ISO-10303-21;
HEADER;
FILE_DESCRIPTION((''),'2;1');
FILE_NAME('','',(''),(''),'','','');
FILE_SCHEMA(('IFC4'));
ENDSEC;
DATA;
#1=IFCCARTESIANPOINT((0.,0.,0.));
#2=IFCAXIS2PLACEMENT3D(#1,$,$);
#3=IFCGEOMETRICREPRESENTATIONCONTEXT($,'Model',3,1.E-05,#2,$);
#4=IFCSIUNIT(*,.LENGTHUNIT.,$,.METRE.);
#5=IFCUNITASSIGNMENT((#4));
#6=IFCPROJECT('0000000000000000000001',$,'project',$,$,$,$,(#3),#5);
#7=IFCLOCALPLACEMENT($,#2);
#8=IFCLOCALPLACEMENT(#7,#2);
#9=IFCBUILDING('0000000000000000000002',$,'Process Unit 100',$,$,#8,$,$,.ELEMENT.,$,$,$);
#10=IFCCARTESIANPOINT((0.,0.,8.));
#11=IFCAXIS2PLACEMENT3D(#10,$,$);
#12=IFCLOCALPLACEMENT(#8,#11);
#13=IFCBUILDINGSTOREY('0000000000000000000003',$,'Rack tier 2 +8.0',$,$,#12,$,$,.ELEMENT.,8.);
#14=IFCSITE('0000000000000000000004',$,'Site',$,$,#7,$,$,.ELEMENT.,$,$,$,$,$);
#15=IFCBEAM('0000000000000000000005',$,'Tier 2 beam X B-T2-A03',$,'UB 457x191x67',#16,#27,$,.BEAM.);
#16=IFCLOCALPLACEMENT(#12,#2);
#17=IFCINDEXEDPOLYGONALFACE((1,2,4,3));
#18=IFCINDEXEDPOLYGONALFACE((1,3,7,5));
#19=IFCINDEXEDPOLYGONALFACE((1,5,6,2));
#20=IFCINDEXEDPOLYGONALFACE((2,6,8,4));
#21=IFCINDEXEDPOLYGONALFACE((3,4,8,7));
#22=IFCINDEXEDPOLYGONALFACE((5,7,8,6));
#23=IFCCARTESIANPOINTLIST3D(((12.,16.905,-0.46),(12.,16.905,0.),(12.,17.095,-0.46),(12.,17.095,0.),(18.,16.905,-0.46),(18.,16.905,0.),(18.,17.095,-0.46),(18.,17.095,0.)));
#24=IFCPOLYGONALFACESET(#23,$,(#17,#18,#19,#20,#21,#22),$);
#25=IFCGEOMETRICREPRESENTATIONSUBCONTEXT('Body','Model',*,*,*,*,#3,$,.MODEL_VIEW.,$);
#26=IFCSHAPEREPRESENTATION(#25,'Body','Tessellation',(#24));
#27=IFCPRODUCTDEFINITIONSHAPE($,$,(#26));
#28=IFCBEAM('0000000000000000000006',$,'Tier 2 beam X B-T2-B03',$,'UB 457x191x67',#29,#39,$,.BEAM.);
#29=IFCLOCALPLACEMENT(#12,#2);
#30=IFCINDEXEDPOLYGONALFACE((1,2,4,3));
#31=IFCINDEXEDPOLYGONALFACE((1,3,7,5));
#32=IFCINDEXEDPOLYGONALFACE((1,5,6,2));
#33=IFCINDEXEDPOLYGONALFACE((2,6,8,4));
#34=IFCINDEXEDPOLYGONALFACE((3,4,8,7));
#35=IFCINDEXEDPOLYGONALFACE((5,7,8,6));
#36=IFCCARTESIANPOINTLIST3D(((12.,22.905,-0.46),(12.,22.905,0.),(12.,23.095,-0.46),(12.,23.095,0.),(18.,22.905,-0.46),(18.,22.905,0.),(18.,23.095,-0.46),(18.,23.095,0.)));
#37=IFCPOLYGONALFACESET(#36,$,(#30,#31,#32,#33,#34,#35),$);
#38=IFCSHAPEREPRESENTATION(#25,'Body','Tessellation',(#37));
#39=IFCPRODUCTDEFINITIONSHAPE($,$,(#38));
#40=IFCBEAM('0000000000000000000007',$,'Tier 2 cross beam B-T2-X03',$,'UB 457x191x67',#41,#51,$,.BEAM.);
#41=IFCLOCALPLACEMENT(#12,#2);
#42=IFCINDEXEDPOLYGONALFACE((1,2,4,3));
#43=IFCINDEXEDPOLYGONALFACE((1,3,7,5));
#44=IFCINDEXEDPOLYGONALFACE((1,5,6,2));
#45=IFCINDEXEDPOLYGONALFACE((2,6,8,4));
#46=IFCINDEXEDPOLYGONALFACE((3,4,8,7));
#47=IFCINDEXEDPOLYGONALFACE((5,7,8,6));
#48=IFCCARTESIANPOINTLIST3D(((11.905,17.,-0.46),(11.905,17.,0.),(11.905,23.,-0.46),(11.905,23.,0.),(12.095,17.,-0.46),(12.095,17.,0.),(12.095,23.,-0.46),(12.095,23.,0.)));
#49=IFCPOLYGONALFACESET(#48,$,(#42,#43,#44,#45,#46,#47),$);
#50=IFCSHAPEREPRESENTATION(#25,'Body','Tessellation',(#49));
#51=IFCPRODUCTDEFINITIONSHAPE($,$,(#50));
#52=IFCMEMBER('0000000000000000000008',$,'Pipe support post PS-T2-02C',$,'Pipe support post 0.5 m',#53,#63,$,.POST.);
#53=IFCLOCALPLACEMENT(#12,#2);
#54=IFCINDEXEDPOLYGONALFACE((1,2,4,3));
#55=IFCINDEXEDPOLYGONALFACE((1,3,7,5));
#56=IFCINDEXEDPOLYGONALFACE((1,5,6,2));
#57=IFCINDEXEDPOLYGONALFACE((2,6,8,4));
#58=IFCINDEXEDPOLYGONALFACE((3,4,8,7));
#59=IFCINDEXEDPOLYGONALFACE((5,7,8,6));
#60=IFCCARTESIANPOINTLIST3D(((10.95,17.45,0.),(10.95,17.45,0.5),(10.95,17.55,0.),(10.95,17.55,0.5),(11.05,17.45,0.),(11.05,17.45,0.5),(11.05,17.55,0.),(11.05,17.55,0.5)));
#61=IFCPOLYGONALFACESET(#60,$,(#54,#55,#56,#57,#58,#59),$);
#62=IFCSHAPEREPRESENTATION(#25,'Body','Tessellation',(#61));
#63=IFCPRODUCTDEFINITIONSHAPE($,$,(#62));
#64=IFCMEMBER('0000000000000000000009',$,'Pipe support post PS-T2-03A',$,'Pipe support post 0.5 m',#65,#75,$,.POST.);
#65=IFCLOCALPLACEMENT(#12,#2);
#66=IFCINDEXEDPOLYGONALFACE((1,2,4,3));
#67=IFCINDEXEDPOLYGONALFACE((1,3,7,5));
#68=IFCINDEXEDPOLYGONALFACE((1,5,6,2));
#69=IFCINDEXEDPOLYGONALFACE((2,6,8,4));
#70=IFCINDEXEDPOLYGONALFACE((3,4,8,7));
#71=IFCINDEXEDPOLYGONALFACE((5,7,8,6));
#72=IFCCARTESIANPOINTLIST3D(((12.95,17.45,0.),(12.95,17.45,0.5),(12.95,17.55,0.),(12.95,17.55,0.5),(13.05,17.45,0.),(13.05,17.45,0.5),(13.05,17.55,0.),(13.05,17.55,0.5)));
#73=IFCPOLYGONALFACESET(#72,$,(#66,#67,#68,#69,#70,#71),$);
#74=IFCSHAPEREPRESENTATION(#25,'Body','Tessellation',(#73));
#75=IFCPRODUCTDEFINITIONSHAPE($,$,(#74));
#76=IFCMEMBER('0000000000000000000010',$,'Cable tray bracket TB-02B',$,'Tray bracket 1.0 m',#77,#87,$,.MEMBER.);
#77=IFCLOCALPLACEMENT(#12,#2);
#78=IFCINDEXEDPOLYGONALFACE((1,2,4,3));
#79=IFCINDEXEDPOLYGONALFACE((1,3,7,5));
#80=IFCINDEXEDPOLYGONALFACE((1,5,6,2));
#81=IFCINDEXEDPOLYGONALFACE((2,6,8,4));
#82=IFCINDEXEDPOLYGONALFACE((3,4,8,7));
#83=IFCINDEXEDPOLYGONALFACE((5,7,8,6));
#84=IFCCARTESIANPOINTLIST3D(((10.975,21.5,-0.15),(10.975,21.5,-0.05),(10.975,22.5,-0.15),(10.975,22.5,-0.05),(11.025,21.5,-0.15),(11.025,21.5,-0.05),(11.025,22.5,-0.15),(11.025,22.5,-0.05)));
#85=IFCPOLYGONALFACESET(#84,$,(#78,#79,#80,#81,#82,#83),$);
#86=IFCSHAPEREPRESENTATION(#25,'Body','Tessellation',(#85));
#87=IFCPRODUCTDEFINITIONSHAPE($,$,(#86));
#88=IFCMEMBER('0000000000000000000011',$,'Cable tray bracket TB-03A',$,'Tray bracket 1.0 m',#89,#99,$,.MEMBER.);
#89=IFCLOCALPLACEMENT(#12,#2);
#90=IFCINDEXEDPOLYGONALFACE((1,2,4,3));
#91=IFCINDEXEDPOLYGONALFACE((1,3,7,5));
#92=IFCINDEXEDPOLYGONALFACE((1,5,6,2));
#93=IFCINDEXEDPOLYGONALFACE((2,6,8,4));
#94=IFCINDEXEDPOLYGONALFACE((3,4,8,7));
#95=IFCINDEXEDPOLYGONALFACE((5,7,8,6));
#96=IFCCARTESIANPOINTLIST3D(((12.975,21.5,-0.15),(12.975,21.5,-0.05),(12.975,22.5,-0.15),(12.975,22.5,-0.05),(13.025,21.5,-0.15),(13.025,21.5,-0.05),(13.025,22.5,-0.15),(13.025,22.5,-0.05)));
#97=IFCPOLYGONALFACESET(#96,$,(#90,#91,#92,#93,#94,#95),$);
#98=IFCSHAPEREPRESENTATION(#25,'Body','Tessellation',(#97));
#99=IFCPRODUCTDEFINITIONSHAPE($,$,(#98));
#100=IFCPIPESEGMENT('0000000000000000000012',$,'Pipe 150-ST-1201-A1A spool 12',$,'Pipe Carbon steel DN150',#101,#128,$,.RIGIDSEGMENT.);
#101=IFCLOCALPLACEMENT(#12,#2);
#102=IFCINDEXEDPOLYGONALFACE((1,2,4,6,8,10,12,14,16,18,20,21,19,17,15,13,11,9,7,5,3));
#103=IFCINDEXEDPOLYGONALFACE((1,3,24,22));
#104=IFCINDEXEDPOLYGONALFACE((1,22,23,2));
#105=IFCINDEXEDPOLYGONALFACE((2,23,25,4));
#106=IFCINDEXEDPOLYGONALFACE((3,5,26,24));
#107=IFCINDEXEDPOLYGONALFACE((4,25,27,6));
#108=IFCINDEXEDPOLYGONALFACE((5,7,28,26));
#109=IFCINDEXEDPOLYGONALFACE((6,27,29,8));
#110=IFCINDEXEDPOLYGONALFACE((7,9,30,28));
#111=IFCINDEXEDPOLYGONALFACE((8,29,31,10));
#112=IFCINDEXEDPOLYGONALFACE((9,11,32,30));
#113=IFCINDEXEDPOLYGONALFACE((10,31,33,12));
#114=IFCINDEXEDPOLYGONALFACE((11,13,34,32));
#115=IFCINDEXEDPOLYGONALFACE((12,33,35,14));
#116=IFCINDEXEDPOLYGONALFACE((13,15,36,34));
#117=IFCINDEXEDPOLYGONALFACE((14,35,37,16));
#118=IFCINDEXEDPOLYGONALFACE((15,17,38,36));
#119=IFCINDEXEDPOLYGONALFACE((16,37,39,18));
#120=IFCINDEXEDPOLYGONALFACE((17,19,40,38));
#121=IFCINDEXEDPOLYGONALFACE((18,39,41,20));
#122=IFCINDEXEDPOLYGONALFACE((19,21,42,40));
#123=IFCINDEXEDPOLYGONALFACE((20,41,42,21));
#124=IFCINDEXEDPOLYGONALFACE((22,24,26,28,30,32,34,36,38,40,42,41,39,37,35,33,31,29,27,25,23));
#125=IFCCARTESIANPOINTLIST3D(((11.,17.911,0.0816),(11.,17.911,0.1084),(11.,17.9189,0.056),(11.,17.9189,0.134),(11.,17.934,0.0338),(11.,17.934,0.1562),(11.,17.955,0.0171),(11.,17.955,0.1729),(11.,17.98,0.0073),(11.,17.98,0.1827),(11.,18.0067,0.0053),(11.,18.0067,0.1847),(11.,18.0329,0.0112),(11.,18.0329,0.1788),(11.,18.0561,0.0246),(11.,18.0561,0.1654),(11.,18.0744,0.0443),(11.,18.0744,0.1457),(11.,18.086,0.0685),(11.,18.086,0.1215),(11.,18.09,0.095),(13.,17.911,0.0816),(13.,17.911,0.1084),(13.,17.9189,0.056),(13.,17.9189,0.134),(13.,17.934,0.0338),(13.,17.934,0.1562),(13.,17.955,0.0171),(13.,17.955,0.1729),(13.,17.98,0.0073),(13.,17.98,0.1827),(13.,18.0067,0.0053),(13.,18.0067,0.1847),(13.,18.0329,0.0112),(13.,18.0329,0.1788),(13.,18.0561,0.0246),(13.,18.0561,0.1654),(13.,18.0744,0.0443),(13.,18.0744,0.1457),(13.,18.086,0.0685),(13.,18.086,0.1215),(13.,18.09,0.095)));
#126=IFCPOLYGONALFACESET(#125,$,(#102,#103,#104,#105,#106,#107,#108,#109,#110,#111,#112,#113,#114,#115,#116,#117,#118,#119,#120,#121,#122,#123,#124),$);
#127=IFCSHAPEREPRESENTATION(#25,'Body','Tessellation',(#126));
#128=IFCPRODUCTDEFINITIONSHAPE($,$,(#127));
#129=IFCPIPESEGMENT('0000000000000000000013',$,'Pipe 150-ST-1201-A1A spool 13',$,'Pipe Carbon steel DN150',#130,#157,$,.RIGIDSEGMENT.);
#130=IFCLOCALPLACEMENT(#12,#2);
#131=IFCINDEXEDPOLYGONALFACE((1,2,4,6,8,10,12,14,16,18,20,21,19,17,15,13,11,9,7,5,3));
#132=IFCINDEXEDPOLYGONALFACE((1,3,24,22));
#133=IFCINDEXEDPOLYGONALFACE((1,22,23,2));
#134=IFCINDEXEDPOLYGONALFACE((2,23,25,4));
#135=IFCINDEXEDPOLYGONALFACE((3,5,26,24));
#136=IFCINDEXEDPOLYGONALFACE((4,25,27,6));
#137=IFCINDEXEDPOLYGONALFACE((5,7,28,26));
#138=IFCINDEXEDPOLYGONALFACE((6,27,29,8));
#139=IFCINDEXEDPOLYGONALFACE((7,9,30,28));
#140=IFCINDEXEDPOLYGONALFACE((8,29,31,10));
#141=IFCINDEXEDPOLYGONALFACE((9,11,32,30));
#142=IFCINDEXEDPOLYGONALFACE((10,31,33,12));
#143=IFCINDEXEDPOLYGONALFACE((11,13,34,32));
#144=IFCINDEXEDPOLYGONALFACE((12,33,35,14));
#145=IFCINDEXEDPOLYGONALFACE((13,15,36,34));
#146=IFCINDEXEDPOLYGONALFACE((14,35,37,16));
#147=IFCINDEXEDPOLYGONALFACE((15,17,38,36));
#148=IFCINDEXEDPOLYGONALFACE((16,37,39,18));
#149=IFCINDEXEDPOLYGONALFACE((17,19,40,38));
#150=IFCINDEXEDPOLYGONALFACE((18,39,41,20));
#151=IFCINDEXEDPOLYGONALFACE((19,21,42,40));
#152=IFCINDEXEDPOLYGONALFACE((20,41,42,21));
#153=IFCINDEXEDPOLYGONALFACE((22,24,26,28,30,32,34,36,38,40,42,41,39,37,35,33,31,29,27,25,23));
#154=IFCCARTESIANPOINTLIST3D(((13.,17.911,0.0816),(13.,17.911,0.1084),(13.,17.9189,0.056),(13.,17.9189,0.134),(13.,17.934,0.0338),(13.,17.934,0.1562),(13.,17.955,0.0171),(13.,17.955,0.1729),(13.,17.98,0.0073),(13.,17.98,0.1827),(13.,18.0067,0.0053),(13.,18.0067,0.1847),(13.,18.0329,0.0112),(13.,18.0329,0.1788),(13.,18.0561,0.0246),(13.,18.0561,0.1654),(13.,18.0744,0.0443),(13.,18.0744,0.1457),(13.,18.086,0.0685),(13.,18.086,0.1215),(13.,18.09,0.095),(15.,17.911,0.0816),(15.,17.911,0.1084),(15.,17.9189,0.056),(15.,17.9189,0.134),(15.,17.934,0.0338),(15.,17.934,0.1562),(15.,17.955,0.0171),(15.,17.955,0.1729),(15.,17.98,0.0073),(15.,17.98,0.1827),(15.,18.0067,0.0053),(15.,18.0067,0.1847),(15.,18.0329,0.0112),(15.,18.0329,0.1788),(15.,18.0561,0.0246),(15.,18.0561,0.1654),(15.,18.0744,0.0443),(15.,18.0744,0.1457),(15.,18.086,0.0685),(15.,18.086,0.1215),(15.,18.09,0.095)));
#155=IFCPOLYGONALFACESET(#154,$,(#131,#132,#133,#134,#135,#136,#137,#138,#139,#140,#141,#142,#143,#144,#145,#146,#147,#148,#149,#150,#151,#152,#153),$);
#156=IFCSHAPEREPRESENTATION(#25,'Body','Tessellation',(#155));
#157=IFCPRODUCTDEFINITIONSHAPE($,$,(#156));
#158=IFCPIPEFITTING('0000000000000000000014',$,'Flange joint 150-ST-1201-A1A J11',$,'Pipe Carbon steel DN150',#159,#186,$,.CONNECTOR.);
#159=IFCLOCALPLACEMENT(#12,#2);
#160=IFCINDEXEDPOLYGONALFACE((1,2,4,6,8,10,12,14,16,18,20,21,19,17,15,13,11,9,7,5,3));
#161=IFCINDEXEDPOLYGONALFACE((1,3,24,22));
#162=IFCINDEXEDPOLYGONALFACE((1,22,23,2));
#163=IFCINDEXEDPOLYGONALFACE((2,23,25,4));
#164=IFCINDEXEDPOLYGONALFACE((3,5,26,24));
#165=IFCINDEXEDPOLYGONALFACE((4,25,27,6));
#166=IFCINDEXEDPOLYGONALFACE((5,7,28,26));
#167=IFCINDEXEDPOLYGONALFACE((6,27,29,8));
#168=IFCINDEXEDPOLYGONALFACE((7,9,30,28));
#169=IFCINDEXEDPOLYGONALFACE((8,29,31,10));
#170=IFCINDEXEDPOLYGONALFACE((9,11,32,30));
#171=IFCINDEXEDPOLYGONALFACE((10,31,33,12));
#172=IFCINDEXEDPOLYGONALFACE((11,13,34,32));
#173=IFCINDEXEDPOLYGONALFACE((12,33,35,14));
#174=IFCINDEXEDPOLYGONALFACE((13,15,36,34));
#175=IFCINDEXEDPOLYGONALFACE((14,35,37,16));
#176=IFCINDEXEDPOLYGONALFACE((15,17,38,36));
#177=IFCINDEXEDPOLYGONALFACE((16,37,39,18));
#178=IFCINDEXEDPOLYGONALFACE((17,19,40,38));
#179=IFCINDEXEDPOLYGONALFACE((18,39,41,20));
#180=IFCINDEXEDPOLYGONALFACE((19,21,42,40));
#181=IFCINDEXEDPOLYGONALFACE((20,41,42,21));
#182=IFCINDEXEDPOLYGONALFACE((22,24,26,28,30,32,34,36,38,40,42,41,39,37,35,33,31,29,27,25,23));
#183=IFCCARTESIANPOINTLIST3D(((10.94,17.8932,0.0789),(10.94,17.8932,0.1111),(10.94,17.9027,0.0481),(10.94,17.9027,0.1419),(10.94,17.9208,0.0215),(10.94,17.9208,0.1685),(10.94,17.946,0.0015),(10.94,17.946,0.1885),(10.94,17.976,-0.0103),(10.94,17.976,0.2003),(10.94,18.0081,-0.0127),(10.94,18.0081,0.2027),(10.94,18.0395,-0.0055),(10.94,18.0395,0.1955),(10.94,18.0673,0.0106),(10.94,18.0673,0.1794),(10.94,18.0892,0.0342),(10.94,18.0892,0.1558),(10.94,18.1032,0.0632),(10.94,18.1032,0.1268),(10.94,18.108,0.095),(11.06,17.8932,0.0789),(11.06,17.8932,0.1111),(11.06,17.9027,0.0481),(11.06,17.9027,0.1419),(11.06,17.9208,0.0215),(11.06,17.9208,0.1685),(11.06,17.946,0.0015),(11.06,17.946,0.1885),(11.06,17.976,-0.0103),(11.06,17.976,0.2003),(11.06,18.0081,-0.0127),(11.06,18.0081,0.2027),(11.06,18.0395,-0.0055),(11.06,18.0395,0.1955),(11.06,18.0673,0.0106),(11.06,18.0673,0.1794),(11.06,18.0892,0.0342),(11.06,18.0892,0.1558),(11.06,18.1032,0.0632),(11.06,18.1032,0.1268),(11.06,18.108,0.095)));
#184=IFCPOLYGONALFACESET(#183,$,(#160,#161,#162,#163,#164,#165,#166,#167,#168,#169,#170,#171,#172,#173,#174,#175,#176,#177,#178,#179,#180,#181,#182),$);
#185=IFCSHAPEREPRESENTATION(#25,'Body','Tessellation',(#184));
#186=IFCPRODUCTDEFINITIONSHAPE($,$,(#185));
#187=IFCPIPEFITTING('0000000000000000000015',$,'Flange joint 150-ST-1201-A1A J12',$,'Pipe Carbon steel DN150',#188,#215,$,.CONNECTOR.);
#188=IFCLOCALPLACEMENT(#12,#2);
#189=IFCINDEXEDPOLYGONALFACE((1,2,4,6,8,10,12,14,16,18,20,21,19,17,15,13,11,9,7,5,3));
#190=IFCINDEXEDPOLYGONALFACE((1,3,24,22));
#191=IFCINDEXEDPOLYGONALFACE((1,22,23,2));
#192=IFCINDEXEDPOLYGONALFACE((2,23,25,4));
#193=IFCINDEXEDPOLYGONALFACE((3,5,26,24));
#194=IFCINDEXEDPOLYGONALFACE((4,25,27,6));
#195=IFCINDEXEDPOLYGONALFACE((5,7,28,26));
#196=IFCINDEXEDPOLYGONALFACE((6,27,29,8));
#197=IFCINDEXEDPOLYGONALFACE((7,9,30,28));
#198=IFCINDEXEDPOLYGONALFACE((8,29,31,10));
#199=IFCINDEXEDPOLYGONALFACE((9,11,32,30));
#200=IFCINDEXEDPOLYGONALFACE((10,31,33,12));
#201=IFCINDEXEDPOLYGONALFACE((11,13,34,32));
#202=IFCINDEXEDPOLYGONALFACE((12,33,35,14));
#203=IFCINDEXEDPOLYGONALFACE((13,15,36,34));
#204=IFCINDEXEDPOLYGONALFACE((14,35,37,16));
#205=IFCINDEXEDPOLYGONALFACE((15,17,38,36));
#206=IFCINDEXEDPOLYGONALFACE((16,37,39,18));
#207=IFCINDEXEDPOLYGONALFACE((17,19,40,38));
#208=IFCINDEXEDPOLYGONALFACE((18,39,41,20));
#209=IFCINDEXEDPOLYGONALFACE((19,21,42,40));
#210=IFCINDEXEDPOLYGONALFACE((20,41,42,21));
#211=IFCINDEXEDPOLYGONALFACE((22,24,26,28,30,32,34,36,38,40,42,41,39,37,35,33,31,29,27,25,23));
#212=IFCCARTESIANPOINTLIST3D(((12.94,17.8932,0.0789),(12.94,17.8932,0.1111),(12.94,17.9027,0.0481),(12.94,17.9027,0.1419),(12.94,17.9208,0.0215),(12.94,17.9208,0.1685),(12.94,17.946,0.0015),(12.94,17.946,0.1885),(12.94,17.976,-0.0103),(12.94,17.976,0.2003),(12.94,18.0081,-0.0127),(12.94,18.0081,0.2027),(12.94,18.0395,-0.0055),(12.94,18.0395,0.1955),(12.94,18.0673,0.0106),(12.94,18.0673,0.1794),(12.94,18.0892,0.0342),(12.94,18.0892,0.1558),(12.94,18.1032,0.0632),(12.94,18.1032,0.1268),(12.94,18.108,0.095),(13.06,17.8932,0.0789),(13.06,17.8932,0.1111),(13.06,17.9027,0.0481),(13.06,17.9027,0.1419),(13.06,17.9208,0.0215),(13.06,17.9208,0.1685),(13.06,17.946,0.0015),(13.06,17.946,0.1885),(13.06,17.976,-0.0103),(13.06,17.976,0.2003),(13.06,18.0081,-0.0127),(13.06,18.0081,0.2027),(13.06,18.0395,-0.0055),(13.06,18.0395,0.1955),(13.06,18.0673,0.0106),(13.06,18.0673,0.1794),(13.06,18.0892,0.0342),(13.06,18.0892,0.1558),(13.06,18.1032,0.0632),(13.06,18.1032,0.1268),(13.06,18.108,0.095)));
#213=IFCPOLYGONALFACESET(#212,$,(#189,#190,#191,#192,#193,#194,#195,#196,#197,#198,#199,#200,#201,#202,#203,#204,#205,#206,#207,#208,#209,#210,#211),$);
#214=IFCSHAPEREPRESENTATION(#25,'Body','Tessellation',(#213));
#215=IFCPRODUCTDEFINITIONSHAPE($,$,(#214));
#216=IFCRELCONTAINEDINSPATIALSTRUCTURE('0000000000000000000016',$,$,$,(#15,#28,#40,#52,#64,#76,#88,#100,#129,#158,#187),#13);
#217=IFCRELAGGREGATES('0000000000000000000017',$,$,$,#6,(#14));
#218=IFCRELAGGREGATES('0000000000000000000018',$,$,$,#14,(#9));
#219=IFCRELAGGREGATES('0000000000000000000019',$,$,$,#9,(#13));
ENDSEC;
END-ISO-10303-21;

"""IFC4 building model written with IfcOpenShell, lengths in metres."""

from ifc_helpers import new_model, si_unit, frame, origin, place, context, subcontext, project, spatial, rectangle, circle, extrude, element, save


model = new_model("IFC4")

# Units and contexts
model_context = context("Model", 3, precision=1e-05, world=origin())
body_context = subcontext(model_context, "Body", "Model", "MODEL_VIEW")
ifc_project = project(units=[si_unit("LENGTHUNIT", "METRE")], contexts=[model_context])

# Site, building, storey
site_placement = place(None, origin())
site = spatial("IfcSite", under=ifc_project, at=site_placement, Name="Site", CompositionType="ELEMENT")
building_placement = place(site_placement, origin())
building = spatial("IfcBuilding", under=site, at=building_placement, Name="Process Unit 100", CompositionType="ELEMENT")
storey_placement = place(building_placement, frame((0.0, 0.0, 8.0)))
storey = spatial("IfcBuildingStorey", under=building, at=storey_placement, Name="Rack tier 2 +8.0", CompositionType="ELEMENT", Elevation=8.0)

# Beams
for number, where, z_axis, x_axis, name in (
    (1, (12.0, 17.0, -0.23), (1.0, 0.0, 0.0), (0.0, 1.0, 0.0), "Tier 2 beam X B-T2-A03"),
    (2, (12.0, 23.0, -0.23), (1.0, 0.0, 0.0), (0.0, 1.0, 0.0), "Tier 2 beam X B-T2-B03"),
    (3, (12.0, 17.0, -0.23), (0.0, 1.0, 0.0), (-1.0, 0.0, 0.0), "Tier 2 cross beam B-T2-X03"),
):
    element("IfcBeam", number, at=place(storey_placement, frame(where, z_axis=z_axis, x_axis=x_axis)), inside=storey, Name=name, ObjectType="UB 457x191x67", PredefinedType="BEAM", context=body_context, shape_type="SweptSolid", body=[
        extrude(rectangle(XDim=0.19, YDim=0.46), origin(), (0.0, 0.0, 1.0), 6.0),
    ])

# Members
for number, where, z_axis, x_axis, name in (
    (4, (11.0, 17.5, 0.0), (0.0, 0.0, 1.0), (1.0, 0.0, 0.0), "Pipe support post PS-T2-02C"),
    (5, (13.0, 17.5, 0.0), (0.0, 0.0, 1.0), (1.0, 0.0, 0.0), "Pipe support post PS-T2-03A"),
):
    element("IfcMember", number, at=place(storey_placement, frame(where, z_axis=z_axis, x_axis=x_axis)), inside=storey, Name=name, ObjectType="Pipe support post 0.5 m", PredefinedType="POST", context=body_context, shape_type="SweptSolid", body=[
        extrude(rectangle(XDim=0.1, YDim=0.1), origin(), (0.0, 0.0, 1.0), 0.5),
    ])
for number, where, z_axis, x_axis, name in (
    (6, (11.0, 21.5, -0.1), (0.0, 1.0, 0.0), (-1.0, 0.0, 0.0), "Cable tray bracket TB-02B"),
    (7, (13.0, 21.5, -0.1), (0.0, 1.0, 0.0), (-1.0, 0.0, 0.0), "Cable tray bracket TB-03A"),
):
    element("IfcMember", number, at=place(storey_placement, frame(where, z_axis=z_axis, x_axis=x_axis)), inside=storey, Name=name, ObjectType="Tray bracket 1.0 m", PredefinedType="MEMBER", context=body_context, shape_type="SweptSolid", body=[
        extrude(rectangle(XDim=0.05, YDim=0.1), origin(), (0.0, 0.0, 1.0), 1.0),
    ])

# Pipe segments
for number, where, z_axis, x_axis, name in (
    (8, (11.0, 18.0, 0.095), (1.0, 0.0, 0.0), (0.0, 1.0, 0.0), "Pipe 150-ST-1201-A1A spool 12"),
    (9, (13.0, 18.0, 0.095), (1.0, 0.0, 0.0), (0.0, 1.0, 0.0), "Pipe 150-ST-1201-A1A spool 13"),
):
    element("IfcPipeSegment", number, at=place(storey_placement, frame(where, z_axis=z_axis, x_axis=x_axis)), inside=storey, Name=name, ObjectType="Pipe Carbon steel DN150", PredefinedType="RIGIDSEGMENT", context=body_context, shape_type="SweptSolid", body=[
        extrude(circle(Radius=0.09), origin(), (0.0, 0.0, 1.0), 2.0),
    ])

# Pipe fittings
for number, where, z_axis, x_axis, name in (
    (10, (10.94, 18.0, 0.095), (1.0, 0.0, 0.0), (0.0, 1.0, 0.0), "Flange joint 150-ST-1201-A1A J11"),
    (11, (12.94, 18.0, 0.095), (1.0, 0.0, 0.0), (0.0, 1.0, 0.0), "Flange joint 150-ST-1201-A1A J12"),
):
    element("IfcPipeFitting", number, at=place(storey_placement, frame(where, z_axis=z_axis, x_axis=x_axis)), inside=storey, Name=name, ObjectType="Pipe Carbon steel DN150", PredefinedType="CONNECTOR", context=body_context, shape_type="SweptSolid", body=[
        extrude(circle(Radius=0.108), origin(), (0.0, 0.0, 1.0), 0.12),
    ])

save(model, "model.ifc")
